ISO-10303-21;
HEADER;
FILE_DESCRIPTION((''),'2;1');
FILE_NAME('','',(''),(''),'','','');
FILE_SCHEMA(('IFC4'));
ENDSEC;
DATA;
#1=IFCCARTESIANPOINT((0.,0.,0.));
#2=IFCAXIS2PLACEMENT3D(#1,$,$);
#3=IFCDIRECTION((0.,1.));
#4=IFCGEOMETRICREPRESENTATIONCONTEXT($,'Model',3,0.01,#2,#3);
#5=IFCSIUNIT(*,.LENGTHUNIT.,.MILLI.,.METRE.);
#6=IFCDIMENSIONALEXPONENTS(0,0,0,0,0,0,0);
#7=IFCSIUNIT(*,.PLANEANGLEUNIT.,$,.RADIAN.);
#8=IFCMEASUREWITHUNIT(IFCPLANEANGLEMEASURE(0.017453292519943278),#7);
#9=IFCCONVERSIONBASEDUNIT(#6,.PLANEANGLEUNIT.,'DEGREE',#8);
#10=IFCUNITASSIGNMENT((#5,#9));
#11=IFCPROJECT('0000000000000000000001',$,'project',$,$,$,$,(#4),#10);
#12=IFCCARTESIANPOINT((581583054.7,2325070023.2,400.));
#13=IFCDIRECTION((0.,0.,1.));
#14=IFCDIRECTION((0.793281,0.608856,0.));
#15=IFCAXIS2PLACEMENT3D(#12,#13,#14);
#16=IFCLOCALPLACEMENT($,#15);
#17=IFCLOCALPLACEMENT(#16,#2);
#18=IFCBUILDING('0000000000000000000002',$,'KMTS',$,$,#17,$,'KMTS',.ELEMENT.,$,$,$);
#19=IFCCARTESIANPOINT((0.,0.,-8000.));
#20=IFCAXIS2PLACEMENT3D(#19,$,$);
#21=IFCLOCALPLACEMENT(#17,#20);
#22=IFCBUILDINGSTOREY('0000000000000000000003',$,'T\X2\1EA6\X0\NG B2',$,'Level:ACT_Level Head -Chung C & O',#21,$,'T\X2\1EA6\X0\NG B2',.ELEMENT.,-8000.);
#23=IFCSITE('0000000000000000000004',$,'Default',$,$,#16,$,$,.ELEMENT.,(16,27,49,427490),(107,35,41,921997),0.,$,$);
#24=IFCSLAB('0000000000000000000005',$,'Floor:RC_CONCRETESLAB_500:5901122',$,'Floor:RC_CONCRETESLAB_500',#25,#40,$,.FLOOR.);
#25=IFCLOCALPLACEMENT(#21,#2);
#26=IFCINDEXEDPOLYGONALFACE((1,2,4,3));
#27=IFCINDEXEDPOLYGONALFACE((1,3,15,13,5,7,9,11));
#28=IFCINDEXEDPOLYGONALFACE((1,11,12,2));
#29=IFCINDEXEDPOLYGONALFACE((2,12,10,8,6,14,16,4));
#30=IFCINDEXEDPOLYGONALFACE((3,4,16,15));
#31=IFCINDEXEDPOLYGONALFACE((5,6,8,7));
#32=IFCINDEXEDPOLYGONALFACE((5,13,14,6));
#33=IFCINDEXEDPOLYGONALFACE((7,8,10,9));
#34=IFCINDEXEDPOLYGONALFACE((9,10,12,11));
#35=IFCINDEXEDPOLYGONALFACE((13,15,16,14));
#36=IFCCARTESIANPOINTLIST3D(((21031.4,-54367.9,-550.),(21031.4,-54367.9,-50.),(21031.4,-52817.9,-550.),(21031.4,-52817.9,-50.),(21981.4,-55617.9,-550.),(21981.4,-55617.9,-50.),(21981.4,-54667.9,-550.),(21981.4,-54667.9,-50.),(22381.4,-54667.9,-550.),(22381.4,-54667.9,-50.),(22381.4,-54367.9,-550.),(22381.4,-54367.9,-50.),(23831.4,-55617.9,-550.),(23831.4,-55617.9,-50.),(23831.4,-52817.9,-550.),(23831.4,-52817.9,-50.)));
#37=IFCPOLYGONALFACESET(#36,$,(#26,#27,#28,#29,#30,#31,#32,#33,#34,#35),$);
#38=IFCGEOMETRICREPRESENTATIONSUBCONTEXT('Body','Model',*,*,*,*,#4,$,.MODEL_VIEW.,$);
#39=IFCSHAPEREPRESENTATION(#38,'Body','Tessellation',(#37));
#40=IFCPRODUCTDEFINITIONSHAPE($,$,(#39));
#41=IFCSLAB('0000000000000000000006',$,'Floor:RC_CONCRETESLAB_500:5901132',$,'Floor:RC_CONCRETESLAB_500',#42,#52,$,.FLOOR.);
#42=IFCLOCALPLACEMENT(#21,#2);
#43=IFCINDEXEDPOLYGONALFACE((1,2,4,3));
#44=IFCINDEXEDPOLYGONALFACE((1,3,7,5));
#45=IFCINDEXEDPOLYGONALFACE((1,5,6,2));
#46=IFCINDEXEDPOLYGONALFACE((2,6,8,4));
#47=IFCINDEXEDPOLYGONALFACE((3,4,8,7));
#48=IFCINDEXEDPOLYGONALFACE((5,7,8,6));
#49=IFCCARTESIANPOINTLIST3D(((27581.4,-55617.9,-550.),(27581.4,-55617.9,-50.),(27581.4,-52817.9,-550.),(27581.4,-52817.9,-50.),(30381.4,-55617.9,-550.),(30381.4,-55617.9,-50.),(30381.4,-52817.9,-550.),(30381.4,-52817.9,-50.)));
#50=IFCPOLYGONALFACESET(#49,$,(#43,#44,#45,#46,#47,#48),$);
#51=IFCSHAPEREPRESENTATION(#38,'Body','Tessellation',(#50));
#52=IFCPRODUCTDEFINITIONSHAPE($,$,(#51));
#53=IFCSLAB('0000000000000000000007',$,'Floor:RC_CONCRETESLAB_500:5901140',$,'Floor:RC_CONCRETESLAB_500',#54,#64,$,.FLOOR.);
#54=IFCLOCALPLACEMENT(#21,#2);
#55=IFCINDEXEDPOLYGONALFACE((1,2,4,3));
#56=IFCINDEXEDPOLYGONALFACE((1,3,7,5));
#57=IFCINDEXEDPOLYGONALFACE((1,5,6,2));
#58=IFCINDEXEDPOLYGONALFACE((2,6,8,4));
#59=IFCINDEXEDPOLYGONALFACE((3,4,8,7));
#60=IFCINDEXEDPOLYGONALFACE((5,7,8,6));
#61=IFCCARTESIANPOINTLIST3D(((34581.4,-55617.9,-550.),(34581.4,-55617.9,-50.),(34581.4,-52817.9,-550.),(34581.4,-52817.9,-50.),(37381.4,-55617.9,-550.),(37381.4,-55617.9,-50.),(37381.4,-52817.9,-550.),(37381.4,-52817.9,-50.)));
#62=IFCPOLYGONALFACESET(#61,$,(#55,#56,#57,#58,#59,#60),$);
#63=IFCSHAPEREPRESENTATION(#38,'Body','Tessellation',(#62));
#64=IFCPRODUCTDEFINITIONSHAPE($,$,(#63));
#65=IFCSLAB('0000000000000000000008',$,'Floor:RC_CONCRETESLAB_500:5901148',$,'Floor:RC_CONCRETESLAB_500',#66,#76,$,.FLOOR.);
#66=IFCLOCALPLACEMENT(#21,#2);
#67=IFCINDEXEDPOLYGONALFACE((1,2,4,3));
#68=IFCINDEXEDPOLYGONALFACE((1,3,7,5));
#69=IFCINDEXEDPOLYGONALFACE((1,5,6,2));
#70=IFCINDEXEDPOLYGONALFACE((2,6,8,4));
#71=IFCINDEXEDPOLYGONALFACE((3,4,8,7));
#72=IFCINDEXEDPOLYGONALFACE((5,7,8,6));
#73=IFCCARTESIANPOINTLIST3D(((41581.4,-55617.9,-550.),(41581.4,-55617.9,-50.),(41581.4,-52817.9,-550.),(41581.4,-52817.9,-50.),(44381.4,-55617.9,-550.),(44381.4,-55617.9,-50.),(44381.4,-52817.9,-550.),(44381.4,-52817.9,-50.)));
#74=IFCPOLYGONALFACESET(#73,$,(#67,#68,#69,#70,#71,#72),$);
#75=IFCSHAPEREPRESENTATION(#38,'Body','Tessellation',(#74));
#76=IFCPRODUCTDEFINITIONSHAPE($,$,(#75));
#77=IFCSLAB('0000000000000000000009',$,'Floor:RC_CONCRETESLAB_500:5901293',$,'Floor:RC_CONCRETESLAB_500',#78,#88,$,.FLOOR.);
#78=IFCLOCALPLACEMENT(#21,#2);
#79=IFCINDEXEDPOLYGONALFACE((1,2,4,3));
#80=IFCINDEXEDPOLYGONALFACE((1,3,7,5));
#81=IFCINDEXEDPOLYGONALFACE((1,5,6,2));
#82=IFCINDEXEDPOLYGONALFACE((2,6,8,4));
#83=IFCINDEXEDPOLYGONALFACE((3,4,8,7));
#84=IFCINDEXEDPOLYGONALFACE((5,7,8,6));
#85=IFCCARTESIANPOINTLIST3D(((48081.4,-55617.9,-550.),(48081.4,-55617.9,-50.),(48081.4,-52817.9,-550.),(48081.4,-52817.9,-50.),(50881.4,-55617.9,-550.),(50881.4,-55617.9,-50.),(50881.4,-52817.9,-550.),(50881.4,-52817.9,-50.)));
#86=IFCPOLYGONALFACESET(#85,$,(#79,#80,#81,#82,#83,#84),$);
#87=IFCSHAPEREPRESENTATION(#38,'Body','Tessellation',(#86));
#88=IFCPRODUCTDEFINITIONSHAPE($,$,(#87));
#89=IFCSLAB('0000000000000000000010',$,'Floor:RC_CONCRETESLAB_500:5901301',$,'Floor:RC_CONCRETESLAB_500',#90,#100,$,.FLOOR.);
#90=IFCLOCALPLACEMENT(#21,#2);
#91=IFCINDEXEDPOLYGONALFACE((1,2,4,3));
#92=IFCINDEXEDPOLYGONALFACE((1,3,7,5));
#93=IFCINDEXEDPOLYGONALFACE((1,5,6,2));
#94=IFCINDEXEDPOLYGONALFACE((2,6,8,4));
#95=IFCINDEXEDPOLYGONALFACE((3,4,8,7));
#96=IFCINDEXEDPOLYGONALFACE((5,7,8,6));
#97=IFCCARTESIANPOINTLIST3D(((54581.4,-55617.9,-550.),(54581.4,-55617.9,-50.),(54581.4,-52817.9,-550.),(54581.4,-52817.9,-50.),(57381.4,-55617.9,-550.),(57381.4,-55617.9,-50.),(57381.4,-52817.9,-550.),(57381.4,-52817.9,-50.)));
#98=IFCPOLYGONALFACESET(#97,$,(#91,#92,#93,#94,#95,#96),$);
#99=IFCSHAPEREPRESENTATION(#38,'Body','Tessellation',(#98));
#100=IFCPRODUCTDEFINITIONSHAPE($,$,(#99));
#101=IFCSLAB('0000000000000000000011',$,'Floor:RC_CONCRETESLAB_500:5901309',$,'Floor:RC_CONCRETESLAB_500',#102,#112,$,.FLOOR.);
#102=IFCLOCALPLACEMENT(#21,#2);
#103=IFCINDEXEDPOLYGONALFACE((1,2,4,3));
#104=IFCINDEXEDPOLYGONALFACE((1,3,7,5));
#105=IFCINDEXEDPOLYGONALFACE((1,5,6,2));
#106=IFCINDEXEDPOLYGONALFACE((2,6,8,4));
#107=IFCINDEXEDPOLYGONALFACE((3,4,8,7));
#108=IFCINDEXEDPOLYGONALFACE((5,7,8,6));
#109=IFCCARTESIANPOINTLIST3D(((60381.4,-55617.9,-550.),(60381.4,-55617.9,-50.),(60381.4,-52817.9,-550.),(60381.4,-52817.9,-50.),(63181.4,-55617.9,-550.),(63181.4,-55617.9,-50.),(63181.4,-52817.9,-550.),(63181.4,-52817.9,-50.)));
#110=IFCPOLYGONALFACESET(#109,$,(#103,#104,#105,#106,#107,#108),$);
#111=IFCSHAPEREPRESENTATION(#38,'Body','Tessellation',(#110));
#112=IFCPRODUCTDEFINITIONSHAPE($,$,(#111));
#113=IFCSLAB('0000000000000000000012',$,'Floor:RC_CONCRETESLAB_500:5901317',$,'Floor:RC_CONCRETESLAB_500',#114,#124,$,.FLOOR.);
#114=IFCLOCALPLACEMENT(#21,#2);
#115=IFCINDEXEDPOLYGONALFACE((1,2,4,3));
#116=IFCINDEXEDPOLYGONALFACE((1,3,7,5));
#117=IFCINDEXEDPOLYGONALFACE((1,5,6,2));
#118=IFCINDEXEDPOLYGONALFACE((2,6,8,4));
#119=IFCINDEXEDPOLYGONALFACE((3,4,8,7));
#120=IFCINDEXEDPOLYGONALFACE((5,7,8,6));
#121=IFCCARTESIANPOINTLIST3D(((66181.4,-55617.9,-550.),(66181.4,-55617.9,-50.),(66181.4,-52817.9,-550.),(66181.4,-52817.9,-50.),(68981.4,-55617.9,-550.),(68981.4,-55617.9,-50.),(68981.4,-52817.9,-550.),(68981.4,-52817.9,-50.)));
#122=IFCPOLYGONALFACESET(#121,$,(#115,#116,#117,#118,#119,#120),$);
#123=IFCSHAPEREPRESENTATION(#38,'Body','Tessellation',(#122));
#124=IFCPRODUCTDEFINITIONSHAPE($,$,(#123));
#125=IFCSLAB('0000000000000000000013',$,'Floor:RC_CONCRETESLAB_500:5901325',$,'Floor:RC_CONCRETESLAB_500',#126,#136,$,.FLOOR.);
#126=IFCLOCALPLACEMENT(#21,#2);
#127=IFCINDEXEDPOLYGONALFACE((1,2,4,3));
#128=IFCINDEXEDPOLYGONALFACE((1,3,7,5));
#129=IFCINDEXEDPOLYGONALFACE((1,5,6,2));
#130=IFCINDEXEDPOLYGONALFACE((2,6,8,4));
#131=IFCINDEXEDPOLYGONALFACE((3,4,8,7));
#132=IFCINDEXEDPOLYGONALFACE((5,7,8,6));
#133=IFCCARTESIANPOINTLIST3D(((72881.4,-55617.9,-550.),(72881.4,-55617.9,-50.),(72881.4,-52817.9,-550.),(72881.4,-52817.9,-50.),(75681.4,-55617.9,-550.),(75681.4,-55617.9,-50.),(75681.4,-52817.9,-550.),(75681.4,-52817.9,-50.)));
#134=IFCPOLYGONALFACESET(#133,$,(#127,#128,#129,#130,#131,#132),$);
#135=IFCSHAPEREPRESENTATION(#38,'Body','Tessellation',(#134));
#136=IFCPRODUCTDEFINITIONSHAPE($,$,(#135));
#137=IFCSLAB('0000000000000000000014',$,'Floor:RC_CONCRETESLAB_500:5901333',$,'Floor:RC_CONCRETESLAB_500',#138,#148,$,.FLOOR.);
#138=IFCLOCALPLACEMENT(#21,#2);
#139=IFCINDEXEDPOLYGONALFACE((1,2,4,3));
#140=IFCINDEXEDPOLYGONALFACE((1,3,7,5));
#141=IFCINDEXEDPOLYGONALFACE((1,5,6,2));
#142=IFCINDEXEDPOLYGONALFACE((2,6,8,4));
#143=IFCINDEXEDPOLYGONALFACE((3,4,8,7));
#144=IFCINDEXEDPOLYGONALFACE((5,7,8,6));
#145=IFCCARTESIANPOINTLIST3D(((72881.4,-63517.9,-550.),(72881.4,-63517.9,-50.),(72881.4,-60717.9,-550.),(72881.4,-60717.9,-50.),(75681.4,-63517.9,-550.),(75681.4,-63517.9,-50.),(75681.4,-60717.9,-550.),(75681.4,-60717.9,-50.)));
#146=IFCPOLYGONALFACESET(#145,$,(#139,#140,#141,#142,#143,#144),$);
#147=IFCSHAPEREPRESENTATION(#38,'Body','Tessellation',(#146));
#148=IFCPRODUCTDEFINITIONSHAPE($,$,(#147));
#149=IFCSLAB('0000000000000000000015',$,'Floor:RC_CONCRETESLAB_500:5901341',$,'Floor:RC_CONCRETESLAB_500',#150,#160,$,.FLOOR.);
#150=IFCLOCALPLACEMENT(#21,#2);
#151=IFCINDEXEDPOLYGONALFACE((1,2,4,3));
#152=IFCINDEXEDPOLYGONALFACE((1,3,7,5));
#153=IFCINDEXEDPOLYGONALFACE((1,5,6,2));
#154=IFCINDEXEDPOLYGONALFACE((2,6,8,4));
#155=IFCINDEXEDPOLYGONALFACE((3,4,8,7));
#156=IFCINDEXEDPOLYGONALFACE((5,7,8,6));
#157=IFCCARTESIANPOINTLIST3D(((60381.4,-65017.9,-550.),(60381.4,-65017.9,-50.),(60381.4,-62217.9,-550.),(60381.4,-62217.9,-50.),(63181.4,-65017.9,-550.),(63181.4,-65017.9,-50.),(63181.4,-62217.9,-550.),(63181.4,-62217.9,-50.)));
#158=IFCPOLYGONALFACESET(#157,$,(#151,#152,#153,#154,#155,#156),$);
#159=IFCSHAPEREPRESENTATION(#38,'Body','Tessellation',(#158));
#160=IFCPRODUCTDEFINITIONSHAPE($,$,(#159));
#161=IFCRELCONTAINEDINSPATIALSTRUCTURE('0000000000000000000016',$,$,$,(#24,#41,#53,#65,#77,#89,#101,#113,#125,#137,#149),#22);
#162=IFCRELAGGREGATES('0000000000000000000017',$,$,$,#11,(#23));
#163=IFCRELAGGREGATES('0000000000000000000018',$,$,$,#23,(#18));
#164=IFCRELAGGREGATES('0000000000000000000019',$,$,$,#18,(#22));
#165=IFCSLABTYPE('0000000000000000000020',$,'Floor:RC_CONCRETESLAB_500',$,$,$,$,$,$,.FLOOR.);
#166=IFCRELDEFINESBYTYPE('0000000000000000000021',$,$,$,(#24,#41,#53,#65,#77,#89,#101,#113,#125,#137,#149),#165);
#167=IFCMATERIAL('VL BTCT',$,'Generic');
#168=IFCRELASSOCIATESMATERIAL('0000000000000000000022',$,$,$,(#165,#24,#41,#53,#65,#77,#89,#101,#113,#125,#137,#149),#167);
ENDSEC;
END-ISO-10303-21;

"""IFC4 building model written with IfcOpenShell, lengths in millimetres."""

from ifc_helpers import new_model, entity, si_unit, converted_unit, direction, frame, origin, place, context, subcontext, project, spatial, indexed_curve, outline, extrude, material, type_object, element, save


model = new_model("IFC4")

# Units and contexts
model_context = context("Model", 3, precision=0.01, world=origin(), true_north=direction((0.0, 1.0)))
body_context = subcontext(model_context, "Body", "Model", "MODEL_VIEW")
ifc_project = project(units=[si_unit("LENGTHUNIT", "METRE", prefix="MILLI"), converted_unit("PLANEANGLEUNIT", "DEGREE", entity("IfcPlaneAngleMeasure", 0.017453292519943278), si_unit("PLANEANGLEUNIT", "RADIAN"), dimensions=[0, 0, 0, 0, 0, 0, 0])], contexts=[model_context])

# Site, building, storey
site_placement = place(None, frame((581583054.7, 2325070023.2, 400.0), z_axis=(0.0, 0.0, 1.0), x_axis=(0.793281, 0.608856, 0.0)))
site = spatial("IfcSite", under=ifc_project, at=site_placement, Name="Default", CompositionType="ELEMENT", RefLatitude=(16, 27, 49, 427490), RefLongitude=(107, 35, 41, 921997), RefElevation=0.0)
building_placement = place(site_placement, origin())
building = spatial("IfcBuilding", under=site, at=building_placement, Name="KMTS", LongName="KMTS", CompositionType="ELEMENT")
storey_placement = place(building_placement, frame((0.0, 0.0, -8000.0)))
storey = spatial("IfcBuildingStorey", under=building, at=storey_placement, Name="TẦNG B2", ObjectType="Level:ACT_Level Head -Chung C & O", LongName="TẦNG B2", CompositionType="ELEMENT", Elevation=-8000.0)

# Shared definitions
ifc_material = material(Name="VL BTCT", Category="Generic")

# Slabs
slab_type_1 = type_object("IfcSlabType", Name="Floor:RC_CONCRETESLAB_500", PredefinedType="FLOOR", material=ifc_material)
slab_1_placement = place(storey_placement, origin())
element("IfcSlab", 1, at=slab_1_placement, inside=storey, type_object=slab_type_1, material=ifc_material, Name="Floor:RC_CONCRETESLAB_500:5901122", ObjectType="Floor:RC_CONCRETESLAB_500", PredefinedType="FLOOR", context=body_context, shape_type="SweptSolid", body=[
    extrude(outline(indexed_curve([(0.0, -1275.0), (1550.0, -1275.0), (1550.0, 1525.0), (-1250.0, 1525.0), (-1250.0, -325.0), (-300.0, -325.0), (-300.0, 75.0), (0.0, 75.0), (0.0, -1275.0)], self_intersect=False)), frame((22306.4, -54367.9, -50.0), z_axis=(0.0, 0.0, -1.0), x_axis=(0.0, 1.0, 0.0)), (0.0, 0.0, 1.0), 500.0),
])
slab_2_placement = place(storey_placement, origin())
element("IfcSlab", 2, at=slab_2_placement, inside=storey, type_object=slab_type_1, material=ifc_material, Name="Floor:RC_CONCRETESLAB_500:5901132", ObjectType="Floor:RC_CONCRETESLAB_500", PredefinedType="FLOOR", context=body_context, shape_type="SweptSolid", body=[
    extrude(outline(indexed_curve([(-1400.0, -1400.0), (1400.0, -1400.0), (1400.0, 1400.0), (-1400.0, 1400.0), (-1400.0, -1400.0)], self_intersect=False)), frame((28981.4, -54217.9, -50.0), z_axis=(0.0, 0.0, -1.0), x_axis=(0.0, 1.0, 0.0)), (0.0, 0.0, 1.0), 500.0),
])
slab_3_placement = place(storey_placement, origin())
element("IfcSlab", 3, at=slab_3_placement, inside=storey, type_object=slab_type_1, material=ifc_material, Name="Floor:RC_CONCRETESLAB_500:5901140", ObjectType="Floor:RC_CONCRETESLAB_500", PredefinedType="FLOOR", context=body_context, shape_type="SweptSolid", body=[
    extrude(outline(indexed_curve([(-1400.0, -1400.0), (1400.0, -1400.0), (1400.0, 1400.0), (-1400.0, 1400.0), (-1400.0, -1400.0)], self_intersect=False)), frame((35981.4, -54217.9, -50.0), z_axis=(0.0, 0.0, -1.0), x_axis=(0.0, 1.0, 0.0)), (0.0, 0.0, 1.0), 500.0),
])
slab_4_placement = place(storey_placement, origin())
element("IfcSlab", 4, at=slab_4_placement, inside=storey, type_object=slab_type_1, material=ifc_material, Name="Floor:RC_CONCRETESLAB_500:5901148", ObjectType="Floor:RC_CONCRETESLAB_500", PredefinedType="FLOOR", context=body_context, shape_type="SweptSolid", body=[
    extrude(outline(indexed_curve([(-1400.0, -1400.0), (1400.0, -1400.0), (1400.0, 1400.0), (-1400.0, 1400.0), (-1400.0, -1400.0)], self_intersect=False)), frame((42981.4, -54217.9, -50.0), z_axis=(0.0, 0.0, -1.0), x_axis=(0.0, 1.0, 0.0)), (0.0, 0.0, 1.0), 500.0),
])
slab_5_placement = place(storey_placement, origin())
element("IfcSlab", 5, at=slab_5_placement, inside=storey, type_object=slab_type_1, material=ifc_material, Name="Floor:RC_CONCRETESLAB_500:5901293", ObjectType="Floor:RC_CONCRETESLAB_500", PredefinedType="FLOOR", context=body_context, shape_type="SweptSolid", body=[
    extrude(outline(indexed_curve([(-1400.0, -1400.0), (1400.0, -1400.0), (1400.0, 1400.0), (-1400.0, 1400.0), (-1400.0, -1400.0)], self_intersect=False)), frame((49481.4, -54217.9, -50.0), z_axis=(0.0, 0.0, -1.0), x_axis=(0.0, 1.0, 0.0)), (0.0, 0.0, 1.0), 500.0),
])
slab_6_placement = place(storey_placement, origin())
element("IfcSlab", 6, at=slab_6_placement, inside=storey, type_object=slab_type_1, material=ifc_material, Name="Floor:RC_CONCRETESLAB_500:5901301", ObjectType="Floor:RC_CONCRETESLAB_500", PredefinedType="FLOOR", context=body_context, shape_type="SweptSolid", body=[
    extrude(outline(indexed_curve([(-1400.0, -1400.0), (1400.0, -1400.0), (1400.0, 1400.0), (-1400.0, 1400.0), (-1400.0, -1400.0)], self_intersect=False)), frame((55981.4, -54217.9, -50.0), z_axis=(0.0, 0.0, -1.0), x_axis=(0.0, 1.0, 0.0)), (0.0, 0.0, 1.0), 500.0),
])
slab_7_placement = place(storey_placement, origin())
element("IfcSlab", 7, at=slab_7_placement, inside=storey, type_object=slab_type_1, material=ifc_material, Name="Floor:RC_CONCRETESLAB_500:5901309", ObjectType="Floor:RC_CONCRETESLAB_500", PredefinedType="FLOOR", context=body_context, shape_type="SweptSolid", body=[
    extrude(outline(indexed_curve([(-1400.0, -1400.0), (1400.0, -1400.0), (1400.0, 1400.0), (-1400.0, 1400.0), (-1400.0, -1400.0)], self_intersect=False)), frame((61781.4, -54217.9, -50.0), z_axis=(0.0, 0.0, -1.0), x_axis=(0.0, 1.0, 0.0)), (0.0, 0.0, 1.0), 500.0),
])
slab_8_placement = place(storey_placement, origin())
element("IfcSlab", 8, at=slab_8_placement, inside=storey, type_object=slab_type_1, material=ifc_material, Name="Floor:RC_CONCRETESLAB_500:5901317", ObjectType="Floor:RC_CONCRETESLAB_500", PredefinedType="FLOOR", context=body_context, shape_type="SweptSolid", body=[
    extrude(outline(indexed_curve([(-1400.0, -1400.0), (1400.0, -1400.0), (1400.0, 1400.0), (-1400.0, 1400.0), (-1400.0, -1400.0)], self_intersect=False)), frame((67581.4, -54217.9, -50.0), z_axis=(0.0, 0.0, -1.0), x_axis=(0.0, 1.0, 0.0)), (0.0, 0.0, 1.0), 500.0),
])
slab_9_placement = place(storey_placement, origin())
element("IfcSlab", 9, at=slab_9_placement, inside=storey, type_object=slab_type_1, material=ifc_material, Name="Floor:RC_CONCRETESLAB_500:5901325", ObjectType="Floor:RC_CONCRETESLAB_500", PredefinedType="FLOOR", context=body_context, shape_type="SweptSolid", body=[
    extrude(outline(indexed_curve([(-1400.0, -1400.0), (1400.0, -1400.0), (1400.0, 1400.0), (-1400.0, 1400.0), (-1400.0, -1400.0)], self_intersect=False)), frame((74281.4, -54217.9, -50.0), z_axis=(0.0, 0.0, -1.0), x_axis=(0.0, 1.0, 0.0)), (0.0, 0.0, 1.0), 500.0),
])
slab_10_placement = place(storey_placement, origin())
element("IfcSlab", 10, at=slab_10_placement, inside=storey, type_object=slab_type_1, material=ifc_material, Name="Floor:RC_CONCRETESLAB_500:5901333", ObjectType="Floor:RC_CONCRETESLAB_500", PredefinedType="FLOOR", context=body_context, shape_type="SweptSolid", body=[
    extrude(outline(indexed_curve([(-1400.0, -1400.0), (1400.0, -1400.0), (1400.0, 1400.0), (-1400.0, 1400.0), (-1400.0, -1400.0)], self_intersect=False)), frame((74281.4, -62117.9, -50.0), z_axis=(0.0, 0.0, -1.0), x_axis=(0.0, 1.0, 0.0)), (0.0, 0.0, 1.0), 500.0),
])
slab_11_placement = place(storey_placement, origin())
element("IfcSlab", 11, at=slab_11_placement, inside=storey, type_object=slab_type_1, material=ifc_material, Name="Floor:RC_CONCRETESLAB_500:5901341", ObjectType="Floor:RC_CONCRETESLAB_500", PredefinedType="FLOOR", context=body_context, shape_type="SweptSolid", body=[
    extrude(outline(indexed_curve([(-1400.0, -1400.0), (1400.0, -1400.0), (1400.0, 1400.0), (-1400.0, 1400.0), (-1400.0, -1400.0)], self_intersect=False)), frame((61781.4, -63617.9, -50.0), z_axis=(0.0, 0.0, -1.0), x_axis=(0.0, 1.0, 0.0)), (0.0, 0.0, 1.0), 500.0),
])

save(model, "model.ifc")
